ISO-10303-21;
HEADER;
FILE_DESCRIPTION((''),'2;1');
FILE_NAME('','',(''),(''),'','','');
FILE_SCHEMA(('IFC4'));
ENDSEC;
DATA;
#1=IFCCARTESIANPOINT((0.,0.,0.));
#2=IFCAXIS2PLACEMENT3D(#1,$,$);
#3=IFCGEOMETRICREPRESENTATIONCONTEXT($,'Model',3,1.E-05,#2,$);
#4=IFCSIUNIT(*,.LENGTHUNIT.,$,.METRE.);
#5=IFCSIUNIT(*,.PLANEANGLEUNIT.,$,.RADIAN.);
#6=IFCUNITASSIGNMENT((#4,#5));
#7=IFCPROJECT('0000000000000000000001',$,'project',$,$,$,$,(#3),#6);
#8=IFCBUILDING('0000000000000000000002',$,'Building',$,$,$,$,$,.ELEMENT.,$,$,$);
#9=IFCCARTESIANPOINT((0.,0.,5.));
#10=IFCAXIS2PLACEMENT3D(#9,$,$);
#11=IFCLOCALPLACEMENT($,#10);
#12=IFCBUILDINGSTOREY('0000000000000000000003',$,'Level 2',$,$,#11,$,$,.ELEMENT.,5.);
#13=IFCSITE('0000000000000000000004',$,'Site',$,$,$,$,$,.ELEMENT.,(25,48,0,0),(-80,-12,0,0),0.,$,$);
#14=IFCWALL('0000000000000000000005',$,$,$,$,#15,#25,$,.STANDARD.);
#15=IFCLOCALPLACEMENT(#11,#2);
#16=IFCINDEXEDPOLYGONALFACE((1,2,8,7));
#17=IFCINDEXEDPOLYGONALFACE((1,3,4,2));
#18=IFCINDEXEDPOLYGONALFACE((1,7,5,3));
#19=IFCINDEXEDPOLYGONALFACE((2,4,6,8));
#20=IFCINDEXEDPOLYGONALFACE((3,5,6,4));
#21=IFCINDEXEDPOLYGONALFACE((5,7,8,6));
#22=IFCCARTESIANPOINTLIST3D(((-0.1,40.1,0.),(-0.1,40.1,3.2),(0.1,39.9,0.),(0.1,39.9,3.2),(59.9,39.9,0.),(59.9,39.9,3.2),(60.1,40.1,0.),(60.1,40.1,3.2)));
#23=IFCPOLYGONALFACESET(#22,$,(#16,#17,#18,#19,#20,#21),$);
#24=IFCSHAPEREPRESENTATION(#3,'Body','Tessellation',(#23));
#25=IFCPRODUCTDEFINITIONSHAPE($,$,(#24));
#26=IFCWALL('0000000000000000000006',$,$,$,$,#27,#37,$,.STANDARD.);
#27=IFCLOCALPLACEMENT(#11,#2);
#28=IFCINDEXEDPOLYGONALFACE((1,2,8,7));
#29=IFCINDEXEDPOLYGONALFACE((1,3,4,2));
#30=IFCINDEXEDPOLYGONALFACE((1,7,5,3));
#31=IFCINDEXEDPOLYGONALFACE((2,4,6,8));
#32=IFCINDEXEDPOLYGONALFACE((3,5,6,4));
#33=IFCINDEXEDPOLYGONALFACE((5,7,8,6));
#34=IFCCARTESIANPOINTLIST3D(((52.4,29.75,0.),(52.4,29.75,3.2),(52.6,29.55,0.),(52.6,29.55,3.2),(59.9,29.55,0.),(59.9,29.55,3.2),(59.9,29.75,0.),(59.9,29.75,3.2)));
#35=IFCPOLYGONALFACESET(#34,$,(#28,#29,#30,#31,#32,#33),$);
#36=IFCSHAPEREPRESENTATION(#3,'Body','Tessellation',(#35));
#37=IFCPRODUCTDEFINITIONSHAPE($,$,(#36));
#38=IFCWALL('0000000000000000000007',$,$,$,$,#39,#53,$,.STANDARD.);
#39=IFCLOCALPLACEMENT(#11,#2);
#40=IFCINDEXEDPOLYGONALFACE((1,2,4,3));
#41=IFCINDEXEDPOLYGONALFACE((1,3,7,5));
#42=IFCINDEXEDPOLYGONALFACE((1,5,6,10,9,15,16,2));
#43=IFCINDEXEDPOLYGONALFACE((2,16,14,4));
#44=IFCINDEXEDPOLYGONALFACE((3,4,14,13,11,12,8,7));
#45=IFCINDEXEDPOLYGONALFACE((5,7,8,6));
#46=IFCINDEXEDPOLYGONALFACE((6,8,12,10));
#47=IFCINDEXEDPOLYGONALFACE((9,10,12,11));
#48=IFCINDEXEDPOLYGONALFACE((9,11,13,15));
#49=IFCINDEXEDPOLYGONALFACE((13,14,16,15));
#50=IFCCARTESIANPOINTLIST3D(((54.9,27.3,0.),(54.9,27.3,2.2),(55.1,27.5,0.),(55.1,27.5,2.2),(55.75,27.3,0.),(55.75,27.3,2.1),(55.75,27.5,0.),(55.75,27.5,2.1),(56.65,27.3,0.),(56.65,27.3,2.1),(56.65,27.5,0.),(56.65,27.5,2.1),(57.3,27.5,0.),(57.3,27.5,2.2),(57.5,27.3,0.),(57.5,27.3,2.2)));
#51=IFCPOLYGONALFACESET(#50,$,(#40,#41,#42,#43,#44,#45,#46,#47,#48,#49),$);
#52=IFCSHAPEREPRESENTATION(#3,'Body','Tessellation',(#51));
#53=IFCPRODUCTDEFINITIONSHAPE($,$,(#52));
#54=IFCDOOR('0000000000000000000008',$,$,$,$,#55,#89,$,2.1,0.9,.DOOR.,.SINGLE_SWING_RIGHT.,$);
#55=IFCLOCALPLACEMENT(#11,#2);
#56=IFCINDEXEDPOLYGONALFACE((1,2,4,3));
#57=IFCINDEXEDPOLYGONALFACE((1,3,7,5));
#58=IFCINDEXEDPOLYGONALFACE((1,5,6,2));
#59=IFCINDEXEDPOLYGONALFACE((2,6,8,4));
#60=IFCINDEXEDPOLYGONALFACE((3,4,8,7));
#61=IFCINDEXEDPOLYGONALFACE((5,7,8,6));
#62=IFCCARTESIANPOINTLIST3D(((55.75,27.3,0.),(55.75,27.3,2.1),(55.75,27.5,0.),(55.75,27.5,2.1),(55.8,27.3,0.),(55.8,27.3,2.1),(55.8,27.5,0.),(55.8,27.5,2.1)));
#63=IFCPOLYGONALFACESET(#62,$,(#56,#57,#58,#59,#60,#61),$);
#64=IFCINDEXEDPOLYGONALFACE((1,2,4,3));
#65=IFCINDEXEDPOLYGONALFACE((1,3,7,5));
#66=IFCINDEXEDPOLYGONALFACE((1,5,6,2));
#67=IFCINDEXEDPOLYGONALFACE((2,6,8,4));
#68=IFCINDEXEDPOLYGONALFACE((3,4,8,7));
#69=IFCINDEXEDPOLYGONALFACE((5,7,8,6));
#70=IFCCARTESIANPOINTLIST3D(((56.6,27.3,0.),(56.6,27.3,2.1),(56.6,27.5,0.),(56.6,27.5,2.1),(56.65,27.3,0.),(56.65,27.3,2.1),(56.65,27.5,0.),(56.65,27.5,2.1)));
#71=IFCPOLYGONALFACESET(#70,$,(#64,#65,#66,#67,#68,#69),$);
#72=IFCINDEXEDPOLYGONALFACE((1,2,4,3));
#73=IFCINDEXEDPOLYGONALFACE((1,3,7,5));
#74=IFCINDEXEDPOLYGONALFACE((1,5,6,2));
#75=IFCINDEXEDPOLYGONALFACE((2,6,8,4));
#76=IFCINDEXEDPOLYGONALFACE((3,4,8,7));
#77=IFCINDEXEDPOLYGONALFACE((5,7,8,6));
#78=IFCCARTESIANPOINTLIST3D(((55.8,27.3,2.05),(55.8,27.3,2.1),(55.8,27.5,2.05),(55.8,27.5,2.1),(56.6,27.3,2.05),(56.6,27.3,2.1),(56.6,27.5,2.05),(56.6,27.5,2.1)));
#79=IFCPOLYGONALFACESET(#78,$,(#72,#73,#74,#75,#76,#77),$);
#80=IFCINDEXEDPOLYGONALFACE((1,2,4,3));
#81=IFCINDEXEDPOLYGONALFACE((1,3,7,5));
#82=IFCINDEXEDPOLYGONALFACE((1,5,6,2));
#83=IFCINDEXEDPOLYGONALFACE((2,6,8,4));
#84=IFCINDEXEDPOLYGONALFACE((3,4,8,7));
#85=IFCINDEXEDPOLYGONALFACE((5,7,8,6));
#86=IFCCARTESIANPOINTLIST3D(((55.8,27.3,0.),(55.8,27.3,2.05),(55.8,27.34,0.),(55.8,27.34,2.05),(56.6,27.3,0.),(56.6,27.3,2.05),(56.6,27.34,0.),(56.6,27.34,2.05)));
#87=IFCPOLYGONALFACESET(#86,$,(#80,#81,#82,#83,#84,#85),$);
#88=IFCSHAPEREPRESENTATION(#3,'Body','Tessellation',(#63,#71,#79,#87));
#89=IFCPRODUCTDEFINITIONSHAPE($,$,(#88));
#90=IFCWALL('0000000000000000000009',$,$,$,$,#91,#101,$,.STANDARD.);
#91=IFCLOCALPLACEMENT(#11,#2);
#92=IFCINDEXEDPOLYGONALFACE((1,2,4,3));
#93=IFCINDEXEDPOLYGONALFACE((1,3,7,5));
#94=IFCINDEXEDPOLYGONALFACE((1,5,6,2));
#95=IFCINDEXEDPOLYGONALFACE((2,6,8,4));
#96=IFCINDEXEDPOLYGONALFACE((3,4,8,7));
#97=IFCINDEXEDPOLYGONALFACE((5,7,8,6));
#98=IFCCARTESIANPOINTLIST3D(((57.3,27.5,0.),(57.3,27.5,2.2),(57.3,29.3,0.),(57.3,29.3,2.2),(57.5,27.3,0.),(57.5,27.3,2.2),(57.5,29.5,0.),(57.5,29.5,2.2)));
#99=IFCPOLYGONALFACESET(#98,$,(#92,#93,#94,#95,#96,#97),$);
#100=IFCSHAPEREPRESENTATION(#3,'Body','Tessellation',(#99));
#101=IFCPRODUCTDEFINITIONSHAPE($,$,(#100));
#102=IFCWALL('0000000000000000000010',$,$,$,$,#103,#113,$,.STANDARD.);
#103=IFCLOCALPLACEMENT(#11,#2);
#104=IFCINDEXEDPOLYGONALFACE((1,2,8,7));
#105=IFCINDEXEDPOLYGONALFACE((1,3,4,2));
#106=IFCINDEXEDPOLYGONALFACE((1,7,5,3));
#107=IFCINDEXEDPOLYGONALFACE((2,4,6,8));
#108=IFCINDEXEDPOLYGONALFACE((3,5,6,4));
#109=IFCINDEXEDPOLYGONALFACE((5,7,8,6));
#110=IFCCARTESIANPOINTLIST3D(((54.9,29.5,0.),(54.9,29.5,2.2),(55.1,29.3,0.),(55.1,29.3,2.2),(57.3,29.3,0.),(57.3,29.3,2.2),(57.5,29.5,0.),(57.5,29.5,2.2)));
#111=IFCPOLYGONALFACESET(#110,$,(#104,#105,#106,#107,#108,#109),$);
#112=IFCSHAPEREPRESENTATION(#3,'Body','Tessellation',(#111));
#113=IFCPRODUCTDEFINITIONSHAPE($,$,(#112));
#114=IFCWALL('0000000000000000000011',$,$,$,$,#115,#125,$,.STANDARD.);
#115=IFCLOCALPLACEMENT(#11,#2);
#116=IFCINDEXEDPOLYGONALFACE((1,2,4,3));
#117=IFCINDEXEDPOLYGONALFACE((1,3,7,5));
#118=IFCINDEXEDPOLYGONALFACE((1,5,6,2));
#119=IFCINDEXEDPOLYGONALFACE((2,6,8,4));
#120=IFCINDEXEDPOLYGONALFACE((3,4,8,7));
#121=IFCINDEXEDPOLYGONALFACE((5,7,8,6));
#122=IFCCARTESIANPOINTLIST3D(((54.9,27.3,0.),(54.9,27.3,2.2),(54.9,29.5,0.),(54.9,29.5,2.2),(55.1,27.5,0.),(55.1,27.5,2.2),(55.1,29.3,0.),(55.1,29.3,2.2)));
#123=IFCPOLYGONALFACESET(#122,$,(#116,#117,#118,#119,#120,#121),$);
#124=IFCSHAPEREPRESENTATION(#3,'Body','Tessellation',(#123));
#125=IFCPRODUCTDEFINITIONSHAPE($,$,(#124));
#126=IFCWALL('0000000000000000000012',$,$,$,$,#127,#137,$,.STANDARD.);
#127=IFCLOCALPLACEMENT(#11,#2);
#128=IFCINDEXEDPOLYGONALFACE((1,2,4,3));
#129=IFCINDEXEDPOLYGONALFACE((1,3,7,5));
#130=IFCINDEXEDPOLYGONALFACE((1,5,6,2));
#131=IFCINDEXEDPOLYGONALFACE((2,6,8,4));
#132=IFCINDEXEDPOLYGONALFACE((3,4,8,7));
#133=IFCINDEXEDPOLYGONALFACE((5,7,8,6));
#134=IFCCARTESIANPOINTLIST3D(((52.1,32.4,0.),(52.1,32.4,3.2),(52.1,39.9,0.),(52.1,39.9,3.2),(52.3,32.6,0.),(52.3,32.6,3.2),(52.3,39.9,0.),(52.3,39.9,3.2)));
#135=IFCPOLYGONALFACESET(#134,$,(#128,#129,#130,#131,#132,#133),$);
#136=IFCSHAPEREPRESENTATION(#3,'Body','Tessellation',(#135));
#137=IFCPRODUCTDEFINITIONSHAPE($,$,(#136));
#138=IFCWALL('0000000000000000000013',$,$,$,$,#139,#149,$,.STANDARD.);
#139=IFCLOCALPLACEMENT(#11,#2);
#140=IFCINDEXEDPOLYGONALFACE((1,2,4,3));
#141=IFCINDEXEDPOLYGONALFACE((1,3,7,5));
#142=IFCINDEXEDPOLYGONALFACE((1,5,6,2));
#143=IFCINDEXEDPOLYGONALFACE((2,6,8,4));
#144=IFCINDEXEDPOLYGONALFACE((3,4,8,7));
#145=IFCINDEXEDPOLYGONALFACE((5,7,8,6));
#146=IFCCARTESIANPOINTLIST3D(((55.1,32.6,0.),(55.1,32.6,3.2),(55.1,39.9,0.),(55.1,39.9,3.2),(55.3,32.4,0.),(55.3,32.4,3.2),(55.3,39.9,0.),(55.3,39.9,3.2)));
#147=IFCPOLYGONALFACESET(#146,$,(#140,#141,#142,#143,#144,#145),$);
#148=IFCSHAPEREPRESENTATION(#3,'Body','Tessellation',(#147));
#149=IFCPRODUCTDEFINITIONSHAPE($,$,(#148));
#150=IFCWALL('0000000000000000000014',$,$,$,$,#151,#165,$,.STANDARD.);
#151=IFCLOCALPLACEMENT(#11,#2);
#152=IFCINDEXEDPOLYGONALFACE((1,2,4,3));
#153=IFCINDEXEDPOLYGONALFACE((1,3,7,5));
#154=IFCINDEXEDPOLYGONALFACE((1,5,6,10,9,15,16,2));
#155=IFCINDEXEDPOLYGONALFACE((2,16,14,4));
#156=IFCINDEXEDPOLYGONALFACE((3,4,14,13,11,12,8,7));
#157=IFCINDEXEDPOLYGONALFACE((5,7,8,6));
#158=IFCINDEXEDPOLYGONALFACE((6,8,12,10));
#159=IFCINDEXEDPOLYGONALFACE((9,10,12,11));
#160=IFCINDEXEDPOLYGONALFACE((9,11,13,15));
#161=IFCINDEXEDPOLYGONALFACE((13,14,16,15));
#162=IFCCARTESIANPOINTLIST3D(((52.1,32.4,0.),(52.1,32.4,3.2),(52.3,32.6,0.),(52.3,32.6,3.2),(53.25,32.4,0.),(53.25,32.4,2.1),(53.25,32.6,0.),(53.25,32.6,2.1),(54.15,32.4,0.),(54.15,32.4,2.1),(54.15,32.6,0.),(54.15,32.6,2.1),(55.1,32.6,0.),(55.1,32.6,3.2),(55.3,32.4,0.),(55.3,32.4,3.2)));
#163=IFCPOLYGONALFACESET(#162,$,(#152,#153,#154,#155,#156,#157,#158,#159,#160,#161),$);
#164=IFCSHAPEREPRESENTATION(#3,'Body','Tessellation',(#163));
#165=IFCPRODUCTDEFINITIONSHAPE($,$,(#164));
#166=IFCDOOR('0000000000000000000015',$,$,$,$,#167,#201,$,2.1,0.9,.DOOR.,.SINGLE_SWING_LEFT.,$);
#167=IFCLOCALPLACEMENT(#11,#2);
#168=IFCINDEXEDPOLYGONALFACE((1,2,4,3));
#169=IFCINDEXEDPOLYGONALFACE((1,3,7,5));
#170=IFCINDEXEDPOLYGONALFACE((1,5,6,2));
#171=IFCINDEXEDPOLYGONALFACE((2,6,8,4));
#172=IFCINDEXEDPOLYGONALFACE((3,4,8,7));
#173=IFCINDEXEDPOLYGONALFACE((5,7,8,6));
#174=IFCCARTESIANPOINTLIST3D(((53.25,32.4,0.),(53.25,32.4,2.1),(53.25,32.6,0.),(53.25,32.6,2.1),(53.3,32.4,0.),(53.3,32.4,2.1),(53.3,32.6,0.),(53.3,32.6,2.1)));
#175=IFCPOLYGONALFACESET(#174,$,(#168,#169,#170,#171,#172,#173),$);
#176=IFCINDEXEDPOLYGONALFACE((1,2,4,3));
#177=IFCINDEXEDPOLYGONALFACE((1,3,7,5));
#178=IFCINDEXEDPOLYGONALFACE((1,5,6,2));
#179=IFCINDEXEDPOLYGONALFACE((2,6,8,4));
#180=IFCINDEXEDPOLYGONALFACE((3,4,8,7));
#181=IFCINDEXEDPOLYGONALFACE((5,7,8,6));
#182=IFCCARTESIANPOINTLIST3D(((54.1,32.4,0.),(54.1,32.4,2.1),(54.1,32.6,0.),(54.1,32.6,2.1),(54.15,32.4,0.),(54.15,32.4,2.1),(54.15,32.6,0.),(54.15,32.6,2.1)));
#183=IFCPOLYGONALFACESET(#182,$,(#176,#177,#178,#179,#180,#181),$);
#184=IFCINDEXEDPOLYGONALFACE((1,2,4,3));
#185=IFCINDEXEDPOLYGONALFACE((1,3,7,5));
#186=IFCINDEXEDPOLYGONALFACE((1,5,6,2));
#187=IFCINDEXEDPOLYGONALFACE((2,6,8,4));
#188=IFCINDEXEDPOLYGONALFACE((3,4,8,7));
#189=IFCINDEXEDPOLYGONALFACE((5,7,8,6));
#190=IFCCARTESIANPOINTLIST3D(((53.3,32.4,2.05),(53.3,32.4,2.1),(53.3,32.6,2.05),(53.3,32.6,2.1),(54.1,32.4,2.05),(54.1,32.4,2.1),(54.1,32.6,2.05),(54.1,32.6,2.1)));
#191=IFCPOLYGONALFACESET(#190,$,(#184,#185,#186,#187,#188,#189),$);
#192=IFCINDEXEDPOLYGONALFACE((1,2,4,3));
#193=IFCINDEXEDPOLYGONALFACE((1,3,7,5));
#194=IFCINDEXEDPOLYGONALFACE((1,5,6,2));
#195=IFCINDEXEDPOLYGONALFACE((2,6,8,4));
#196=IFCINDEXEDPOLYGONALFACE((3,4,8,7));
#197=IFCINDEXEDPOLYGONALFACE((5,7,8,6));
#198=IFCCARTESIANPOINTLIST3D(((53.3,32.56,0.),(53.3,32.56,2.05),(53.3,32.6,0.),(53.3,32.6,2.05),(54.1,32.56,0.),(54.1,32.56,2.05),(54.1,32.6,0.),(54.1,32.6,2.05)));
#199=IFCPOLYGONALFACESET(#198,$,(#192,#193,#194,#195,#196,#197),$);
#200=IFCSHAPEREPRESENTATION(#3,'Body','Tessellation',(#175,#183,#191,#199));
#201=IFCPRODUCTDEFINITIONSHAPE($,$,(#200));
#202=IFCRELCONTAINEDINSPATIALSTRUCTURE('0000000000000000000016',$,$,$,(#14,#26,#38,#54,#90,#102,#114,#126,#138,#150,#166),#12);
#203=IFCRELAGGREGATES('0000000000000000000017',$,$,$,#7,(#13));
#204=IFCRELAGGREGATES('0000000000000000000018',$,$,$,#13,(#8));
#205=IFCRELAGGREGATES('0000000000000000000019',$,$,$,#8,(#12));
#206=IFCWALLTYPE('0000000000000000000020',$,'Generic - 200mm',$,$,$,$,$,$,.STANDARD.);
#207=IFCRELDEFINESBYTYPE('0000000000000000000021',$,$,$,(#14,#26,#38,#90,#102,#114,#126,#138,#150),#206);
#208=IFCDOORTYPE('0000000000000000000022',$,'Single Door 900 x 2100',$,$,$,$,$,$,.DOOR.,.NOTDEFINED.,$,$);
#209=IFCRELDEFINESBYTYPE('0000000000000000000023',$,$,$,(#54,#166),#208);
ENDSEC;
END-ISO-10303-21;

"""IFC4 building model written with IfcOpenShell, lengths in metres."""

from ifc_helpers import new_model, si_unit, frame, frame_2d, origin, origin_with_axes, origin_2d, place, context, project, spatial, polyline, rectangle, outline, extrude, type_object, element, fill, save


model = new_model("IFC4")

# Units and contexts
model_context = context("Model", 3, precision=1e-05, world=origin())
ifc_project = project(units=[si_unit("LENGTHUNIT", "METRE"), si_unit("PLANEANGLEUNIT", "RADIAN")], contexts=[model_context])

# Site, building, storey
site = spatial("IfcSite", under=ifc_project, Name="Site", CompositionType="ELEMENT", RefLatitude=(25, 48, 0, 0), RefLongitude=(-80, -12, 0, 0), RefElevation=0.0)
building = spatial("IfcBuilding", under=site, Name="Building", CompositionType="ELEMENT")
storey_placement = place(None, frame((0.0, 0.0, 5.0)))
storey = spatial("IfcBuildingStorey", under=building, at=storey_placement, Name="Level 2", CompositionType="ELEMENT", Elevation=5.0)

# Walls
wall_type = type_object("IfcWallType", Name="Generic - 200mm", PredefinedType="STANDARD")
wall_1_placement = place(None, frame((60.0, 40.0, 5.0), z_axis=(0.0, 0.0, 1.0), x_axis=(-1.0, 0.0, 0.0)))
element("IfcWall", 1, at=wall_1_placement, inside=storey, type_object=wall_type, PredefinedType="STANDARD", context=model_context, shape_type="SweptSolid", body=[
    extrude(outline(polyline([(-0.1, -0.1), (60.1, -0.1), (59.9, 0.1), (0.1, 0.1), (-0.1, -0.1)])), origin(), (0.0, 0.0, 1.0), 3.2),
])
wall_2_placement = place(None, frame((52.5, 29.65, 5.0), z_axis=(0.0, 0.0, 1.0), x_axis=(1.0, 0.0, 0.0)))
element("IfcWall", 2, at=wall_2_placement, inside=storey, type_object=wall_type, PredefinedType="STANDARD", context=model_context, shape_type="SweptSolid", body=[
    extrude(outline(polyline([(0.1, -0.1), (7.4, -0.1), (7.4, 0.1), (-0.1, 0.1), (0.1, -0.1)])), origin(), (0.0, 0.0, 1.0), 3.2),
])

# Wall, opening, door
wall_3_placement = place(None, frame((55.0, 27.4, 5.0), z_axis=(0.0, 0.0, 1.0), x_axis=(1.0, 0.0, 0.0)))
wall_3 = element("IfcWall", 3, at=wall_3_placement, inside=storey, type_object=wall_type, PredefinedType="STANDARD", context=model_context, shape_type="SweptSolid", body=[
    extrude(outline(polyline([(-0.1, -0.1), (2.5, -0.1), (2.3, 0.1), (0.1, 0.1), (-0.1, -0.1)])), origin(), (0.0, 0.0, 1.0), 2.2),
])
opening_1_placement = place(wall_3_placement, frame((1.2, 0.0, 0.0), z_axis=(0.0, 0.0, 1.0), x_axis=(1.0, 0.0, 0.0)))
opening_1 = element("IfcOpeningElement", 4, at=opening_1_placement, cuts=wall_3, PredefinedType="OPENING", context=model_context, shape_type="SweptSolid", body=[
    extrude(rectangle(XDim=0.9, YDim=0.202, at=origin_2d()), origin(), (0.0, 0.0, 1.0), 2.1),
])
door_type = type_object("IfcDoorType", Name="Single Door 900 x 2100", OperationType="NOTDEFINED", PredefinedType="DOOR")
door_1_placement = place(opening_1_placement, origin_with_axes())
door_1 = element("IfcDoor", 5, at=door_1_placement, inside=storey, type_object=door_type, OperationType="SINGLE_SWING_RIGHT", OverallHeight=2.1, OverallWidth=0.9, PredefinedType="DOOR", context=model_context, shape_type="SweptSolid", body=[
    extrude(rectangle(XDim=0.05, YDim=0.2, at=frame_2d((-0.425, 0.0))), origin(), (0.0, 0.0, 1.0), 2.1),
    extrude(rectangle(XDim=0.05, YDim=0.2, at=frame_2d((0.425, 0.0))), origin(), (0.0, 0.0, 1.0), 2.1),
    extrude(rectangle(XDim=0.8, YDim=0.2, at=origin_2d()), frame((0.0, 0.0, 2.05)), (0.0, 0.0, 1.0), 0.05),
    extrude(rectangle(XDim=0.8, YDim=0.04, at=frame_2d((0.0, -0.08))), origin(), (0.0, 0.0, 1.0), 2.05),
])
fill(opening_1, door_1)

# Walls
wall_4_placement = place(None, frame((57.4, 27.4, 5.0), z_axis=(0.0, 0.0, 1.0), x_axis=(0.0, 1.0, 0.0)))
element("IfcWall", 6, at=wall_4_placement, inside=storey, type_object=wall_type, PredefinedType="STANDARD", context=model_context, shape_type="SweptSolid", body=[
    extrude(outline(polyline([(-0.1, -0.1), (2.1, -0.1), (1.9, 0.1), (0.1, 0.1), (-0.1, -0.1)])), origin(), (0.0, 0.0, 1.0), 2.2),
])
wall_5_placement = place(None, frame((57.4, 29.4, 5.0), z_axis=(0.0, 0.0, 1.0), x_axis=(-1.0, 0.0, 0.0)))
element("IfcWall", 7, at=wall_5_placement, inside=storey, type_object=wall_type, PredefinedType="STANDARD", context=model_context, shape_type="SweptSolid", body=[
    extrude(outline(polyline([(-0.1, -0.1), (2.5, -0.1), (2.3, 0.1), (0.1, 0.1), (-0.1, -0.1)])), origin(), (0.0, 0.0, 1.0), 2.2),
])
wall_6_placement = place(None, frame((55.0, 29.4, 5.0), z_axis=(0.0, 0.0, 1.0), x_axis=(0.0, -1.0, 0.0)))
element("IfcWall", 8, at=wall_6_placement, inside=storey, type_object=wall_type, PredefinedType="STANDARD", context=model_context, shape_type="SweptSolid", body=[
    extrude(outline(polyline([(-0.1, -0.1), (2.1, -0.1), (1.9, 0.1), (0.1, 0.1), (-0.1, -0.1)])), origin(), (0.0, 0.0, 1.0), 2.2),
])
wall_7_placement = place(None, frame((52.2, 32.5, 5.0), z_axis=(0.0, 0.0, 1.0), x_axis=(0.0, 1.0, 0.0)))
element("IfcWall", 9, at=wall_7_placement, inside=storey, type_object=wall_type, PredefinedType="STANDARD", context=model_context, shape_type="SweptSolid", body=[
    extrude(outline(polyline([(0.1, -0.1), (7.4, -0.1), (7.4, 0.1), (-0.1, 0.1), (0.1, -0.1)])), origin(), (0.0, 0.0, 1.0), 3.2),
])
wall_8_placement = place(None, frame((55.2, 32.5, 5.0), z_axis=(0.0, 0.0, 1.0), x_axis=(0.0, 1.0, 0.0)))
element("IfcWall", 10, at=wall_8_placement, inside=storey, type_object=wall_type, PredefinedType="STANDARD", context=model_context, shape_type="SweptSolid", body=[
    extrude(outline(polyline([(-0.1, -0.1), (7.4, -0.1), (7.4, 0.1), (0.1, 0.1), (-0.1, -0.1)])), origin(), (0.0, 0.0, 1.0), 3.2),
])

# Wall, opening, door
wall_9_placement = place(None, frame((52.2, 32.5, 5.0), z_axis=(0.0, 0.0, 1.0), x_axis=(1.0, 0.0, 0.0)))
wall_9 = element("IfcWall", 11, at=wall_9_placement, inside=storey, type_object=wall_type, PredefinedType="STANDARD", context=model_context, shape_type="SweptSolid", body=[
    extrude(outline(polyline([(-0.1, -0.1), (3.1, -0.1), (2.9, 0.1), (0.1, 0.1), (-0.1, -0.1)])), origin(), (0.0, 0.0, 1.0), 3.2),
])
opening_2_placement = place(wall_9_placement, frame((1.5, 0.0, 0.0), z_axis=(0.0, 0.0, 1.0), x_axis=(1.0, 0.0, 0.0)))
opening_2 = element("IfcOpeningElement", 12, at=opening_2_placement, cuts=wall_9, PredefinedType="OPENING", context=model_context, shape_type="SweptSolid", body=[
    extrude(rectangle(XDim=0.9, YDim=0.202, at=origin_2d()), origin(), (0.0, 0.0, 1.0), 2.1),
])
door_2_placement = place(opening_2_placement, origin_with_axes())
door_2 = element("IfcDoor", 13, at=door_2_placement, inside=storey, type_object=door_type, OperationType="SINGLE_SWING_LEFT", OverallHeight=2.1, OverallWidth=0.9, PredefinedType="DOOR", context=model_context, shape_type="SweptSolid", body=[
    extrude(rectangle(XDim=0.05, YDim=0.2, at=frame_2d((-0.425, 0.0))), origin(), (0.0, 0.0, 1.0), 2.1),
    extrude(rectangle(XDim=0.05, YDim=0.2, at=frame_2d((0.425, 0.0))), origin(), (0.0, 0.0, 1.0), 2.1),
    extrude(rectangle(XDim=0.8, YDim=0.2, at=origin_2d()), frame((0.0, 0.0, 2.05)), (0.0, 0.0, 1.0), 0.05),
    extrude(rectangle(XDim=0.8, YDim=0.04, at=frame_2d((0.0, 0.08))), origin(), (0.0, 0.0, 1.0), 2.05),
])
fill(opening_2, door_2)

save(model, "model.ifc")
